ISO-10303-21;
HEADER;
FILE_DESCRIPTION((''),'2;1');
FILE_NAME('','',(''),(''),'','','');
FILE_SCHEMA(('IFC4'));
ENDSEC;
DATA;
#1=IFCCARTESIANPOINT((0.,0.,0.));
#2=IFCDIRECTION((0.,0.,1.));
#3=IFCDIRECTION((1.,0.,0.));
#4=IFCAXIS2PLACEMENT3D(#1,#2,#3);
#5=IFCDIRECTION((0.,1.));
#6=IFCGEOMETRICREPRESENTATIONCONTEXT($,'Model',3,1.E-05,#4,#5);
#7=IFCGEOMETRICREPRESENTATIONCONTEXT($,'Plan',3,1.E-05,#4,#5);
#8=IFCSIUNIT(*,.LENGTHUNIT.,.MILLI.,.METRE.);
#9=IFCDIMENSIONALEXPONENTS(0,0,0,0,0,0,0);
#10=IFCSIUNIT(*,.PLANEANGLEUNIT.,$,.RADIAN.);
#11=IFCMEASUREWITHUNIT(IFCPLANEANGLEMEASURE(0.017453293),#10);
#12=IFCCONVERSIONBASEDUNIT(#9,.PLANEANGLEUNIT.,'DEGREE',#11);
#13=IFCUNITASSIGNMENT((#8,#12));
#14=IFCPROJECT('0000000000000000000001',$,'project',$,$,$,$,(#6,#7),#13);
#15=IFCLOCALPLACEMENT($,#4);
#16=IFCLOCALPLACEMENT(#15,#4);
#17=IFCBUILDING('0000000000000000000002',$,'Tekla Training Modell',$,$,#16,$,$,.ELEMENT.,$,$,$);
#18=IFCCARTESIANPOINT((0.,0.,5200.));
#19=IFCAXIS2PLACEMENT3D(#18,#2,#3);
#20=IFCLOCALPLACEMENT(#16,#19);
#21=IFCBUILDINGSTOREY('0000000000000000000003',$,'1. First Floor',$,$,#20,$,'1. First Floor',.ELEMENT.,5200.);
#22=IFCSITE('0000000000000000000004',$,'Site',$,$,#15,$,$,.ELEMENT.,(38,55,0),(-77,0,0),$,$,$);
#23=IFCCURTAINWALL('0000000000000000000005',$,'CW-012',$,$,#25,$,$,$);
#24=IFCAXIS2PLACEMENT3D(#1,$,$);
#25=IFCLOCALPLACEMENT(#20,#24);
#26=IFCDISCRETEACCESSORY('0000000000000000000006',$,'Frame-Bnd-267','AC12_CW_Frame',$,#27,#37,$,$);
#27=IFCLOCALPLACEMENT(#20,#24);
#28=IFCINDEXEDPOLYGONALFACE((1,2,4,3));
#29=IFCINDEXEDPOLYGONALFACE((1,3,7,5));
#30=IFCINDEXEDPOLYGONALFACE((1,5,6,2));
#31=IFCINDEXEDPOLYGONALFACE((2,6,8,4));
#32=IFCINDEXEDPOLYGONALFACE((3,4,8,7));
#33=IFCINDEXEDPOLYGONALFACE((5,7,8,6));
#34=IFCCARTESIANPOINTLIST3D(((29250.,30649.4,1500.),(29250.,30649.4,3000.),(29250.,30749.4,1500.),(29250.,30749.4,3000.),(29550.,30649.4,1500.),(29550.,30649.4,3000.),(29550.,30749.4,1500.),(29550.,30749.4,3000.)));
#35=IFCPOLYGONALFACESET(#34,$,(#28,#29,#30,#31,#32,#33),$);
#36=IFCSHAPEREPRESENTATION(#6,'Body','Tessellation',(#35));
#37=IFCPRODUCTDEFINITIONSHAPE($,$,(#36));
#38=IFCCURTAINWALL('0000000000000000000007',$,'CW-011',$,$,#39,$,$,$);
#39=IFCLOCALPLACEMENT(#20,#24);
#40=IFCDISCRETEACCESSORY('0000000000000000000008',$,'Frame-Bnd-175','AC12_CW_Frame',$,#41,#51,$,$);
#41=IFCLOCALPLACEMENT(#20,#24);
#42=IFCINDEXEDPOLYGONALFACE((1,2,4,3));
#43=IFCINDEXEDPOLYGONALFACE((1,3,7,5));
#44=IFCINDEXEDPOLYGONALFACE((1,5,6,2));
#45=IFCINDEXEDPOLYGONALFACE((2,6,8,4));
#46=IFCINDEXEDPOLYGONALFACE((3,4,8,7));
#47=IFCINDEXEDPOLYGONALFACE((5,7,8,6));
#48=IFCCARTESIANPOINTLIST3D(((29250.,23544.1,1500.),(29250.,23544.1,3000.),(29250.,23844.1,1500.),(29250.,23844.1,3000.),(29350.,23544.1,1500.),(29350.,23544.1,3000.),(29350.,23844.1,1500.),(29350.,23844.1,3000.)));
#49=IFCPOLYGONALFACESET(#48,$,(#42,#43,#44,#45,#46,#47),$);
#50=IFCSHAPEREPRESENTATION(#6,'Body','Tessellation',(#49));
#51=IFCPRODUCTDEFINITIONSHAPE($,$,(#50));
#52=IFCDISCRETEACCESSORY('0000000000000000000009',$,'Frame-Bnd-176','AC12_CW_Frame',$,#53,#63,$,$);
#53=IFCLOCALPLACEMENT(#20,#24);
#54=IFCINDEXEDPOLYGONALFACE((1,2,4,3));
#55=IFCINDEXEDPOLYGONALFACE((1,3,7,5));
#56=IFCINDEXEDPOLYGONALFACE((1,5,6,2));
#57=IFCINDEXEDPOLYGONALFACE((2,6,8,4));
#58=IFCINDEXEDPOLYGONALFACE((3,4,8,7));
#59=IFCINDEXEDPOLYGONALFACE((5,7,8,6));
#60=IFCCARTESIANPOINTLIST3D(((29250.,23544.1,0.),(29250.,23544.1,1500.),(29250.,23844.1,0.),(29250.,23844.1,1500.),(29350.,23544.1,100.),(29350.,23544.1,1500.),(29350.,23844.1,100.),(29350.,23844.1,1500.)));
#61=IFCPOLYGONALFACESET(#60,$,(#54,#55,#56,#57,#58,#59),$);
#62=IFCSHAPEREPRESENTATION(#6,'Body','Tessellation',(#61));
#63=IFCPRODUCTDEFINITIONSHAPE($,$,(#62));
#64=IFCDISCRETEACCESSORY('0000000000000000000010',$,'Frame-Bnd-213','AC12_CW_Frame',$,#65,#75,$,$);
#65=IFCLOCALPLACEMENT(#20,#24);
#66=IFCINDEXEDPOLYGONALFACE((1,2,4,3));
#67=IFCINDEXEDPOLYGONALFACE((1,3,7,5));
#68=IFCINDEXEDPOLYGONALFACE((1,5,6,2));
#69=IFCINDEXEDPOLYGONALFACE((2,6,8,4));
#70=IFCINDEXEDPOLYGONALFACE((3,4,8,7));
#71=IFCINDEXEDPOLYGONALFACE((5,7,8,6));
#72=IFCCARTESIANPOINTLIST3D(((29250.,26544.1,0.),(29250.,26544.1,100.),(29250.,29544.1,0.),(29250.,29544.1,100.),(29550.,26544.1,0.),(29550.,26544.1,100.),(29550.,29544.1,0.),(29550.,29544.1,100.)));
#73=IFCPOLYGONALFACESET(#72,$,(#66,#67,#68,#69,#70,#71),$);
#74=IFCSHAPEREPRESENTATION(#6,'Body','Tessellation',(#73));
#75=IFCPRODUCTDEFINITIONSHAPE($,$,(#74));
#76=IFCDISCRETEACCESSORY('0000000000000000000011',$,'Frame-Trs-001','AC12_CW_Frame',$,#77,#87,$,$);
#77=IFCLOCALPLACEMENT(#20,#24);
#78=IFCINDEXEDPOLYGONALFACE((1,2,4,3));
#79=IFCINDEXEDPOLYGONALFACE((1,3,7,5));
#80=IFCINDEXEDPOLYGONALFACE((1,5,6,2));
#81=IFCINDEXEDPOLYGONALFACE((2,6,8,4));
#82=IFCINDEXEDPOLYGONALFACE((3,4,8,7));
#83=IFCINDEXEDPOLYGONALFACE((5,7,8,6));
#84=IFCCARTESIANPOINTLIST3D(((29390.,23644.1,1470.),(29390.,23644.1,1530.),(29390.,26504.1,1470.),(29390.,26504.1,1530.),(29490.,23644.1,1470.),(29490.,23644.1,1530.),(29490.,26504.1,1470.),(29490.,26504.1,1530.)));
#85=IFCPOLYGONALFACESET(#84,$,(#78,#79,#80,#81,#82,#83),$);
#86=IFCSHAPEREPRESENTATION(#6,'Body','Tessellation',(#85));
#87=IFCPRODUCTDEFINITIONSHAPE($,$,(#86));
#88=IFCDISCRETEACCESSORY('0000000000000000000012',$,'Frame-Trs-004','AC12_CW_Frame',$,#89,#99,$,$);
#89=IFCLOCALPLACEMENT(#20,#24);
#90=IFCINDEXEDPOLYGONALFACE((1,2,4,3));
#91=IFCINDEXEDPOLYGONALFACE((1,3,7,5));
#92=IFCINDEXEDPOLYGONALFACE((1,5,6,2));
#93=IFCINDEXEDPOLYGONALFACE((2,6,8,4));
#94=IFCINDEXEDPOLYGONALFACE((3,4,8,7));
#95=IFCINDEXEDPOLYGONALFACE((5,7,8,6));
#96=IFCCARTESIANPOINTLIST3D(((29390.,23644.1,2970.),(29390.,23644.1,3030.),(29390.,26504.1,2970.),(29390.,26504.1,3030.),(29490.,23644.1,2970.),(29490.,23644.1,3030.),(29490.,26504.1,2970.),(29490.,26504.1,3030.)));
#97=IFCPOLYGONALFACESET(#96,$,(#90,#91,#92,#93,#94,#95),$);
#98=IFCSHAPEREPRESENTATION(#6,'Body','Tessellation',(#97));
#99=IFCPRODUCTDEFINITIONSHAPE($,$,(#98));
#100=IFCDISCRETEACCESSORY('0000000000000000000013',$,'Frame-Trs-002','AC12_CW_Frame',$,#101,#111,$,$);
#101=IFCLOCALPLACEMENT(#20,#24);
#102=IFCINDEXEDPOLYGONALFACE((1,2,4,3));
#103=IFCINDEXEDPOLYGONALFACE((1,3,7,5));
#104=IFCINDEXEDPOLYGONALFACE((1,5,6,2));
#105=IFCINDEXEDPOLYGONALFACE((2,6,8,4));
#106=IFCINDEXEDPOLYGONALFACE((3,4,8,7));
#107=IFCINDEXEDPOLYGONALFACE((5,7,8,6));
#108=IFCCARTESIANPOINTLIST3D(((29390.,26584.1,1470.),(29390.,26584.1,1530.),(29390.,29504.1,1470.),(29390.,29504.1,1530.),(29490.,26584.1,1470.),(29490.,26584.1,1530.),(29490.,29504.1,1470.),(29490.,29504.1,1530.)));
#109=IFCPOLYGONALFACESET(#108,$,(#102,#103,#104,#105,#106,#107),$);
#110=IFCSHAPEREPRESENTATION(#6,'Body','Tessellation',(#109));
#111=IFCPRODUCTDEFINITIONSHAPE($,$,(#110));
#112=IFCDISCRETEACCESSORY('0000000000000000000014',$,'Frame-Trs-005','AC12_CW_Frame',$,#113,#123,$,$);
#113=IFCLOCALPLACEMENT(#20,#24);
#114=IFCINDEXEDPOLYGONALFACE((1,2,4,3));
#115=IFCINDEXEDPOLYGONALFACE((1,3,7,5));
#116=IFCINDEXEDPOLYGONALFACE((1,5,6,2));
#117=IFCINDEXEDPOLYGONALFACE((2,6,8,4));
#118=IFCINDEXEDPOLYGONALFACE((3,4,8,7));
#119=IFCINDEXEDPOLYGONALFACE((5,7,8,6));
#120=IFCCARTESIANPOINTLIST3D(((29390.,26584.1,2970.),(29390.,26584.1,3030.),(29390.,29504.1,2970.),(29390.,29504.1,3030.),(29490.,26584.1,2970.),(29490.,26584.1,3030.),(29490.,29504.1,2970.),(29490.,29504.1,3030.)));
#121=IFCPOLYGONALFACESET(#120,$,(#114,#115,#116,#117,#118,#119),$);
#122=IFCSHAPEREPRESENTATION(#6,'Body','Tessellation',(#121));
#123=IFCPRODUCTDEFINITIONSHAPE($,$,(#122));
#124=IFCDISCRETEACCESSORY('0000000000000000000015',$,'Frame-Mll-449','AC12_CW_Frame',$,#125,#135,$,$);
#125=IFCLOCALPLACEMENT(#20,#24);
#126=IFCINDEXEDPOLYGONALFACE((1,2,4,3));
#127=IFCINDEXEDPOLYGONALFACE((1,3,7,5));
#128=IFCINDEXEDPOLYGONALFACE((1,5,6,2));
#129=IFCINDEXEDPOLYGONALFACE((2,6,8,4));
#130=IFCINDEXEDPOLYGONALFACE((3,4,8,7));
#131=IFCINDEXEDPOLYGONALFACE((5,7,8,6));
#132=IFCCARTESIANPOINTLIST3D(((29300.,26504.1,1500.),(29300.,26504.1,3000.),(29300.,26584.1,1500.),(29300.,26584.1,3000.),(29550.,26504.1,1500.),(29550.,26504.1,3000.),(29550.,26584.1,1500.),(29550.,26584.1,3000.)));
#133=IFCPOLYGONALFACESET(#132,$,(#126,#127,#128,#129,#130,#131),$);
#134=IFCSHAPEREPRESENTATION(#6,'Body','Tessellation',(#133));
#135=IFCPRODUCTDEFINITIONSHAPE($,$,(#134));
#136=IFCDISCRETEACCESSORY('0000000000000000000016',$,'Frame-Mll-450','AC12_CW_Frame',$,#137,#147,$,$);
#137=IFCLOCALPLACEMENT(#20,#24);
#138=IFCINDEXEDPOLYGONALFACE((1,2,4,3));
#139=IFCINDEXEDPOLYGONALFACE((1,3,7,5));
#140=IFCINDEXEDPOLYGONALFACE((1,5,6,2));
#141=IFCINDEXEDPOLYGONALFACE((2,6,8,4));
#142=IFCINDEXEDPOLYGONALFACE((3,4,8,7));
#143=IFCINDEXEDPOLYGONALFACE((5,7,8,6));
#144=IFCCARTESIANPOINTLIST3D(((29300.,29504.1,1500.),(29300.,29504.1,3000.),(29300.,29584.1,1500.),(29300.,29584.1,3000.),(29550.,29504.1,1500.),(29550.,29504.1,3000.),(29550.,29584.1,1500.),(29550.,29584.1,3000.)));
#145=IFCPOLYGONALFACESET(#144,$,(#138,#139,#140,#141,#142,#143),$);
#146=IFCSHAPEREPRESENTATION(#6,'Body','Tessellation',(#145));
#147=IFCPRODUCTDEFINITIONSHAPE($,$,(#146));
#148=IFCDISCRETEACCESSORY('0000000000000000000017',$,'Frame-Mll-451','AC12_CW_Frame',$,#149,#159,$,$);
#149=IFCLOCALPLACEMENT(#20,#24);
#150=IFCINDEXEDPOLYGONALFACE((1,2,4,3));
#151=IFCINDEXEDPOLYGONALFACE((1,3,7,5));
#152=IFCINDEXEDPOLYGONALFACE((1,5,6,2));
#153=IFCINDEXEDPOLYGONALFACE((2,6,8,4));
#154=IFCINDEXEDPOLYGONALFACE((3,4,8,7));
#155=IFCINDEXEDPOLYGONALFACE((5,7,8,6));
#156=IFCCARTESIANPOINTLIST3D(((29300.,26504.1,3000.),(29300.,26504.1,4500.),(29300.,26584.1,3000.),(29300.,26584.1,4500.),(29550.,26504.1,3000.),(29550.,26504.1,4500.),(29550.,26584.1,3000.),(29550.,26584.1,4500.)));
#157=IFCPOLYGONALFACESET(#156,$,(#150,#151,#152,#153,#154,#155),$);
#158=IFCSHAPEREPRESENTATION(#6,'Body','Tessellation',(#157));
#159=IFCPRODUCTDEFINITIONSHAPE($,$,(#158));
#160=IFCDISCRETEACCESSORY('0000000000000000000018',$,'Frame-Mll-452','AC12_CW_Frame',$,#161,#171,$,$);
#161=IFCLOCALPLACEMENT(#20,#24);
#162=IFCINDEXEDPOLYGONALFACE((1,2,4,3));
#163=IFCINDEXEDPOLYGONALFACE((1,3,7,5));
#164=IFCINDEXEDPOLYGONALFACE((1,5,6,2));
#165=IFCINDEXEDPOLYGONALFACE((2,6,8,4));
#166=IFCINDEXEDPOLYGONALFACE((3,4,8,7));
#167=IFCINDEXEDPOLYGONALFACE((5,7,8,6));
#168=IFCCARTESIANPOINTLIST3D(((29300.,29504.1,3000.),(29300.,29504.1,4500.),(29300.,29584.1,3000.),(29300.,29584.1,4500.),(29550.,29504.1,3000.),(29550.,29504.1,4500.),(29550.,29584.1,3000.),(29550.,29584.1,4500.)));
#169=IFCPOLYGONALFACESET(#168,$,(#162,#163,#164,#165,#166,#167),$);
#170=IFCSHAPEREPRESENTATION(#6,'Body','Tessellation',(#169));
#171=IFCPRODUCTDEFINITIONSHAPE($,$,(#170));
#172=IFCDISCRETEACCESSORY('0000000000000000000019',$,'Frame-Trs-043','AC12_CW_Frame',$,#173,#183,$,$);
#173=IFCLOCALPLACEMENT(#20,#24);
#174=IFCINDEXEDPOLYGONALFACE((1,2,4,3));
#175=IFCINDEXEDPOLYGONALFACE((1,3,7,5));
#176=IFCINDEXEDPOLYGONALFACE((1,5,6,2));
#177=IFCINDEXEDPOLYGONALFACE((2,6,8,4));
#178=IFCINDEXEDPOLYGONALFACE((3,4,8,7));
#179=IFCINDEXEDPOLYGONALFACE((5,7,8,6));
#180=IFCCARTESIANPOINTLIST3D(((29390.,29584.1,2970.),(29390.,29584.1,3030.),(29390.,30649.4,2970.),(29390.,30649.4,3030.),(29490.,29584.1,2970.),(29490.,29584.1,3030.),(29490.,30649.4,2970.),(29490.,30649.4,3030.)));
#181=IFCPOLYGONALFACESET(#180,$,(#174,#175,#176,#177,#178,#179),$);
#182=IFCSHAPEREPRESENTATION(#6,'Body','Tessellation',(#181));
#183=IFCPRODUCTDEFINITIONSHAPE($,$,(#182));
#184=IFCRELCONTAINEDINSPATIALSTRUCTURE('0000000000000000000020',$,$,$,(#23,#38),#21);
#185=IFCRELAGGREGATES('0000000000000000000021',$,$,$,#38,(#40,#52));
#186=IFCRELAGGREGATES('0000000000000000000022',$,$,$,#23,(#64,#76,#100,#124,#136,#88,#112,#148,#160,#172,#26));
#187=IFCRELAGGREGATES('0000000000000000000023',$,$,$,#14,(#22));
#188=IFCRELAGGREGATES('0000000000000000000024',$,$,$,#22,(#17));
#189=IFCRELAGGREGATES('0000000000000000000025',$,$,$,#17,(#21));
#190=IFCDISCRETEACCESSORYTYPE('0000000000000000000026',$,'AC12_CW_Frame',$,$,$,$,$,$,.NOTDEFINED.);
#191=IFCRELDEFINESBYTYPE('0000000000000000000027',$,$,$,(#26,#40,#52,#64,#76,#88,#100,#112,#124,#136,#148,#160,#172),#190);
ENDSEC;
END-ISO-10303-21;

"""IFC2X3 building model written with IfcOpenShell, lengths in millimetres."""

from ifc_helpers import new_model, entity, si_unit, converted_unit, direction, frame, origin_with_axes, place, context, project, spatial, polyline, outline, extrude, source, transform, mapped, type_object, element, aggregate, save


model = new_model("IFC2X3")

# Units and contexts
model_context = context("Model", 3, precision=1e-05, world=origin_with_axes(), true_north=direction((0.0, 1.0)))
plan_context = context("Plan", 3, precision=1e-05, world=origin_with_axes(), true_north=direction((0.0, 1.0)))
ifc_project = project(units=[si_unit("LENGTHUNIT", "METRE", prefix="MILLI"), converted_unit("PLANEANGLEUNIT", "DEGREE", entity("IfcPlaneAngleMeasure", 0.017453293), si_unit("PLANEANGLEUNIT", "RADIAN"), dimensions=[0, 0, 0, 0, 0, 0, 0])], contexts=[model_context, plan_context])

# Site, building, storey
site_placement = place(None, origin_with_axes())
site = spatial("IfcSite", under=ifc_project, at=site_placement, Name="Site", CompositionType="ELEMENT", RefLatitude=(38, 55, 0), RefLongitude=(-77, 0, 0))
building_placement = place(site_placement, origin_with_axes())
building = spatial("IfcBuilding", under=site, at=building_placement, Name="Tekla Training Modell", CompositionType="ELEMENT")
storey_placement = place(building_placement, frame((0.0, 0.0, 5200.0), z_axis=(0.0, 0.0, 1.0), x_axis=(1.0, 0.0, 0.0)))
storey = spatial("IfcBuildingStorey", under=building, at=storey_placement, Name="1. First Floor", LongName="1. First Floor", CompositionType="ELEMENT", Elevation=5200.0)

# Curtain wall
curtain_wall_1_placement = place(storey_placement, frame((29500.0, 23544.1, 0.0), z_axis=(0.0, 0.0, 1.0), x_axis=(0.0, 1.0, 0.0)))
curtain_wall_1 = element("IfcCurtainWall", 1, at=curtain_wall_1_placement, inside=storey, Name="CW-012")

# Discrete accessory
discrete_accessory_type = type_object("IfcDiscreteAccessoryType", Name="AC12_CW_Frame")
shared_shape_1 = source(origin_with_axes(), model_context, "Body", "SweptSolid", [
    extrude(outline(polyline([(0.0, 0.0), (300.0, 0.0), (300.0, -1500.0), (0.0, -1500.0), (0.0, 0.0)])), origin_with_axes(), (0.0, 0.0, 1.0), 100.0),
])
discrete_accessory_1_placement = place(storey_placement, frame((29250.0, 30649.4, 1500.0), z_axis=(0.0, 1.0, 0.0), x_axis=(1.0, 0.0, 0.0)))
discrete_accessory_1 = element("IfcDiscreteAccessory", 2, at=discrete_accessory_1_placement, type_object=discrete_accessory_type, Name="Frame-Bnd-267", Description="AC12_CW_Frame", context=model_context, shape_type="MappedRepresentation", body=[
    mapped(shared_shape_1, transform((0.0, 0.0, 0.0), scale=1.0)),
])

# Curtain wall, discrete accessories
curtain_wall_2_placement = place(storey_placement, frame((37350.0, 23794.1, 0.0), z_axis=(0.0, 0.0, 1.0), x_axis=(-1.0, -0.000001, 0.0)))
curtain_wall_2 = element("IfcCurtainWall", 3, at=curtain_wall_2_placement, inside=storey, Name="CW-011")
discrete_accessory_2_placement = place(storey_placement, frame((29350.0, 23544.1, 1500.0), z_axis=(-1.0, 0.0, 0.0), x_axis=(0.0, 1.0, 0.0)))
discrete_accessory_2 = element("IfcDiscreteAccessory", 4, at=discrete_accessory_2_placement, type_object=discrete_accessory_type, Name="Frame-Bnd-175", Description="AC12_CW_Frame", context=model_context, shape_type="MappedRepresentation", body=[
    mapped(shared_shape_1, transform((0.0, 0.0, 0.0), scale=1.0)),
])
shared_shape_2 = source(origin_with_axes(), model_context, "Body", "SweptSolid", [
    extrude(outline(polyline([(0.0, 0.0), (141.4, 0.0), (-919.2, -1060.7), (-989.9, -989.9), (0.0, 0.0)])), origin_with_axes(), (0.0, 0.0, 1.0), 300.0),
])
discrete_accessory_3_placement = place(storey_placement, frame((29350.0, 23844.1, 100.0), z_axis=(0.0, -1.0, 0.0), x_axis=(-0.707107, 0.0, -0.707107)))
discrete_accessory_3 = element("IfcDiscreteAccessory", 5, at=discrete_accessory_3_placement, type_object=discrete_accessory_type, Name="Frame-Bnd-176", Description="AC12_CW_Frame", context=model_context, shape_type="MappedRepresentation", body=[
    mapped(shared_shape_2, transform((0.0, 0.0, 0.0), scale=1.0)),
])
aggregate(curtain_wall_2, [discrete_accessory_2, discrete_accessory_3])

# Discrete accessories
shared_shape_3 = source(origin_with_axes(), model_context, "Body", "SweptSolid", [
    extrude(outline(polyline([(0.0, 0.0), (300.0, 0.0), (300.0, -3000.0), (0.0, -3000.0), (0.0, 0.0)])), origin_with_axes(), (0.0, 0.0, 1.0), 100.0),
])
discrete_accessory_4_placement = place(storey_placement, frame((29250.0, 26544.1, 100.0), z_axis=(0.0, 0.0, -1.0), x_axis=(1.0, 0.0, 0.0)))
discrete_accessory_4 = element("IfcDiscreteAccessory", 6, at=discrete_accessory_4_placement, type_object=discrete_accessory_type, Name="Frame-Bnd-213", Description="AC12_CW_Frame", context=model_context, shape_type="MappedRepresentation", body=[
    mapped(shared_shape_3, transform((0.0, 0.0, 0.0), scale=1.0)),
])
shared_shape_4 = source(origin_with_axes(), model_context, "Body", "SweptSolid", [
    extrude(outline(polyline([(0.0, 0.0), (100.0, 0.0), (100.0, -2860.0), (0.0, -2860.0), (0.0, 0.0)])), origin_with_axes(), (0.0, 0.0, 1.0), 60.0),
])
discrete_accessory_5_placement = place(storey_placement, frame((29390.0, 23644.1, 1530.0), z_axis=(0.0, 0.0, -1.0), x_axis=(1.0, 0.0, 0.0)))
discrete_accessory_5 = element("IfcDiscreteAccessory", 7, at=discrete_accessory_5_placement, type_object=discrete_accessory_type, Name="Frame-Trs-001", Description="AC12_CW_Frame", context=model_context, shape_type="MappedRepresentation", body=[
    mapped(shared_shape_4, transform((0.0, 0.0, 0.0), scale=1.0)),
])
discrete_accessory_6_placement = place(storey_placement, frame((29390.0, 23644.1, 3030.0), z_axis=(0.0, 0.0, -1.0), x_axis=(1.0, 0.0, 0.0)))
discrete_accessory_6 = element("IfcDiscreteAccessory", 8, at=discrete_accessory_6_placement, type_object=discrete_accessory_type, Name="Frame-Trs-004", Description="AC12_CW_Frame", context=model_context, shape_type="MappedRepresentation", body=[
    mapped(shared_shape_4, transform((0.0, 0.0, 0.0), scale=1.0)),
])
shared_shape_5 = source(origin_with_axes(), model_context, "Body", "SweptSolid", [
    extrude(outline(polyline([(0.0, 0.0), (100.0, 0.0), (100.0, -2920.0), (0.0, -2920.0), (0.0, 0.0)])), origin_with_axes(), (0.0, 0.0, 1.0), 60.0),
])
discrete_accessory_7_placement = place(storey_placement, frame((29390.0, 26584.1, 1530.0), z_axis=(0.0, 0.0, -1.0), x_axis=(1.0, 0.0, 0.0)))
discrete_accessory_7 = element("IfcDiscreteAccessory", 9, at=discrete_accessory_7_placement, type_object=discrete_accessory_type, Name="Frame-Trs-002", Description="AC12_CW_Frame", context=model_context, shape_type="MappedRepresentation", body=[
    mapped(shared_shape_5, transform((0.0, 0.0, 0.0), scale=1.0)),
])
discrete_accessory_8_placement = place(storey_placement, frame((29390.0, 26584.1, 3030.0), z_axis=(0.0, 0.0, -1.0), x_axis=(1.0, 0.0, 0.0)))
discrete_accessory_8 = element("IfcDiscreteAccessory", 10, at=discrete_accessory_8_placement, type_object=discrete_accessory_type, Name="Frame-Trs-005", Description="AC12_CW_Frame", context=model_context, shape_type="MappedRepresentation", body=[
    mapped(shared_shape_5, transform((0.0, 0.0, 0.0), scale=1.0)),
])
shared_shape_6 = source(origin_with_axes(), model_context, "Body", "SweptSolid", [
    extrude(outline(polyline([(0.0, 0.0), (250.0, 0.0), (250.0, -1500.0), (0.0, -1500.0), (0.0, 0.0)])), origin_with_axes(), (0.0, 0.0, 1.0), 80.0),
])
discrete_accessory_9_placement = place(storey_placement, frame((29300.0, 26504.1, 1500.0), z_axis=(0.0, 1.0, 0.0), x_axis=(1.0, 0.0, 0.0)))
discrete_accessory_9 = element("IfcDiscreteAccessory", 11, at=discrete_accessory_9_placement, type_object=discrete_accessory_type, Name="Frame-Mll-449", Description="AC12_CW_Frame", context=model_context, shape_type="MappedRepresentation", body=[
    mapped(shared_shape_6, transform((0.0, 0.0, 0.0), scale=1.0)),
])
discrete_accessory_10_placement = place(storey_placement, frame((29300.0, 29504.1, 1500.0), z_axis=(0.0, 1.0, 0.0), x_axis=(1.0, 0.0, 0.0)))
discrete_accessory_10 = element("IfcDiscreteAccessory", 12, at=discrete_accessory_10_placement, type_object=discrete_accessory_type, Name="Frame-Mll-450", Description="AC12_CW_Frame", context=model_context, shape_type="MappedRepresentation", body=[
    mapped(shared_shape_6, transform((0.0, 0.0, 0.0), scale=1.0)),
])
discrete_accessory_11_placement = place(storey_placement, frame((29300.0, 26504.1, 3000.0), z_axis=(0.0, 1.0, 0.0), x_axis=(1.0, 0.0, 0.0)))
discrete_accessory_11 = element("IfcDiscreteAccessory", 13, at=discrete_accessory_11_placement, type_object=discrete_accessory_type, Name="Frame-Mll-451", Description="AC12_CW_Frame", context=model_context, shape_type="MappedRepresentation", body=[
    mapped(shared_shape_6, transform((0.0, 0.0, 0.0), scale=1.0)),
])
discrete_accessory_12_placement = place(storey_placement, frame((29300.0, 29504.1, 3000.0), z_axis=(0.0, 1.0, 0.0), x_axis=(1.0, 0.0, 0.0)))
discrete_accessory_12 = element("IfcDiscreteAccessory", 14, at=discrete_accessory_12_placement, type_object=discrete_accessory_type, Name="Frame-Mll-452", Description="AC12_CW_Frame", context=model_context, shape_type="MappedRepresentation", body=[
    mapped(shared_shape_6, transform((0.0, 0.0, 0.0), scale=1.0)),
])
shared_shape_7 = source(origin_with_axes(), model_context, "Body", "SweptSolid", [
    extrude(outline(polyline([(0.0, 0.0), (100.0, 0.0), (100.0, -1065.3), (0.0, -1065.3), (0.0, 0.0)])), origin_with_axes(), (0.0, 0.0, 1.0), 60.0),
])
discrete_accessory_13_placement = place(storey_placement, frame((29390.0, 29584.1, 3030.0), z_axis=(0.0, 0.0, -1.0), x_axis=(1.0, 0.0, 0.0)))
discrete_accessory_13 = element("IfcDiscreteAccessory", 15, at=discrete_accessory_13_placement, type_object=discrete_accessory_type, Name="Frame-Trs-043", Description="AC12_CW_Frame", context=model_context, shape_type="MappedRepresentation", body=[
    mapped(shared_shape_7, transform((0.0, 0.0, 0.0), scale=1.0)),
])
aggregate(curtain_wall_1, [discrete_accessory_4, discrete_accessory_5, discrete_accessory_7, discrete_accessory_9, discrete_accessory_10, discrete_accessory_6, discrete_accessory_8, discrete_accessory_11, discrete_accessory_12, discrete_accessory_13, discrete_accessory_1])

save(model, "model.ifc")
